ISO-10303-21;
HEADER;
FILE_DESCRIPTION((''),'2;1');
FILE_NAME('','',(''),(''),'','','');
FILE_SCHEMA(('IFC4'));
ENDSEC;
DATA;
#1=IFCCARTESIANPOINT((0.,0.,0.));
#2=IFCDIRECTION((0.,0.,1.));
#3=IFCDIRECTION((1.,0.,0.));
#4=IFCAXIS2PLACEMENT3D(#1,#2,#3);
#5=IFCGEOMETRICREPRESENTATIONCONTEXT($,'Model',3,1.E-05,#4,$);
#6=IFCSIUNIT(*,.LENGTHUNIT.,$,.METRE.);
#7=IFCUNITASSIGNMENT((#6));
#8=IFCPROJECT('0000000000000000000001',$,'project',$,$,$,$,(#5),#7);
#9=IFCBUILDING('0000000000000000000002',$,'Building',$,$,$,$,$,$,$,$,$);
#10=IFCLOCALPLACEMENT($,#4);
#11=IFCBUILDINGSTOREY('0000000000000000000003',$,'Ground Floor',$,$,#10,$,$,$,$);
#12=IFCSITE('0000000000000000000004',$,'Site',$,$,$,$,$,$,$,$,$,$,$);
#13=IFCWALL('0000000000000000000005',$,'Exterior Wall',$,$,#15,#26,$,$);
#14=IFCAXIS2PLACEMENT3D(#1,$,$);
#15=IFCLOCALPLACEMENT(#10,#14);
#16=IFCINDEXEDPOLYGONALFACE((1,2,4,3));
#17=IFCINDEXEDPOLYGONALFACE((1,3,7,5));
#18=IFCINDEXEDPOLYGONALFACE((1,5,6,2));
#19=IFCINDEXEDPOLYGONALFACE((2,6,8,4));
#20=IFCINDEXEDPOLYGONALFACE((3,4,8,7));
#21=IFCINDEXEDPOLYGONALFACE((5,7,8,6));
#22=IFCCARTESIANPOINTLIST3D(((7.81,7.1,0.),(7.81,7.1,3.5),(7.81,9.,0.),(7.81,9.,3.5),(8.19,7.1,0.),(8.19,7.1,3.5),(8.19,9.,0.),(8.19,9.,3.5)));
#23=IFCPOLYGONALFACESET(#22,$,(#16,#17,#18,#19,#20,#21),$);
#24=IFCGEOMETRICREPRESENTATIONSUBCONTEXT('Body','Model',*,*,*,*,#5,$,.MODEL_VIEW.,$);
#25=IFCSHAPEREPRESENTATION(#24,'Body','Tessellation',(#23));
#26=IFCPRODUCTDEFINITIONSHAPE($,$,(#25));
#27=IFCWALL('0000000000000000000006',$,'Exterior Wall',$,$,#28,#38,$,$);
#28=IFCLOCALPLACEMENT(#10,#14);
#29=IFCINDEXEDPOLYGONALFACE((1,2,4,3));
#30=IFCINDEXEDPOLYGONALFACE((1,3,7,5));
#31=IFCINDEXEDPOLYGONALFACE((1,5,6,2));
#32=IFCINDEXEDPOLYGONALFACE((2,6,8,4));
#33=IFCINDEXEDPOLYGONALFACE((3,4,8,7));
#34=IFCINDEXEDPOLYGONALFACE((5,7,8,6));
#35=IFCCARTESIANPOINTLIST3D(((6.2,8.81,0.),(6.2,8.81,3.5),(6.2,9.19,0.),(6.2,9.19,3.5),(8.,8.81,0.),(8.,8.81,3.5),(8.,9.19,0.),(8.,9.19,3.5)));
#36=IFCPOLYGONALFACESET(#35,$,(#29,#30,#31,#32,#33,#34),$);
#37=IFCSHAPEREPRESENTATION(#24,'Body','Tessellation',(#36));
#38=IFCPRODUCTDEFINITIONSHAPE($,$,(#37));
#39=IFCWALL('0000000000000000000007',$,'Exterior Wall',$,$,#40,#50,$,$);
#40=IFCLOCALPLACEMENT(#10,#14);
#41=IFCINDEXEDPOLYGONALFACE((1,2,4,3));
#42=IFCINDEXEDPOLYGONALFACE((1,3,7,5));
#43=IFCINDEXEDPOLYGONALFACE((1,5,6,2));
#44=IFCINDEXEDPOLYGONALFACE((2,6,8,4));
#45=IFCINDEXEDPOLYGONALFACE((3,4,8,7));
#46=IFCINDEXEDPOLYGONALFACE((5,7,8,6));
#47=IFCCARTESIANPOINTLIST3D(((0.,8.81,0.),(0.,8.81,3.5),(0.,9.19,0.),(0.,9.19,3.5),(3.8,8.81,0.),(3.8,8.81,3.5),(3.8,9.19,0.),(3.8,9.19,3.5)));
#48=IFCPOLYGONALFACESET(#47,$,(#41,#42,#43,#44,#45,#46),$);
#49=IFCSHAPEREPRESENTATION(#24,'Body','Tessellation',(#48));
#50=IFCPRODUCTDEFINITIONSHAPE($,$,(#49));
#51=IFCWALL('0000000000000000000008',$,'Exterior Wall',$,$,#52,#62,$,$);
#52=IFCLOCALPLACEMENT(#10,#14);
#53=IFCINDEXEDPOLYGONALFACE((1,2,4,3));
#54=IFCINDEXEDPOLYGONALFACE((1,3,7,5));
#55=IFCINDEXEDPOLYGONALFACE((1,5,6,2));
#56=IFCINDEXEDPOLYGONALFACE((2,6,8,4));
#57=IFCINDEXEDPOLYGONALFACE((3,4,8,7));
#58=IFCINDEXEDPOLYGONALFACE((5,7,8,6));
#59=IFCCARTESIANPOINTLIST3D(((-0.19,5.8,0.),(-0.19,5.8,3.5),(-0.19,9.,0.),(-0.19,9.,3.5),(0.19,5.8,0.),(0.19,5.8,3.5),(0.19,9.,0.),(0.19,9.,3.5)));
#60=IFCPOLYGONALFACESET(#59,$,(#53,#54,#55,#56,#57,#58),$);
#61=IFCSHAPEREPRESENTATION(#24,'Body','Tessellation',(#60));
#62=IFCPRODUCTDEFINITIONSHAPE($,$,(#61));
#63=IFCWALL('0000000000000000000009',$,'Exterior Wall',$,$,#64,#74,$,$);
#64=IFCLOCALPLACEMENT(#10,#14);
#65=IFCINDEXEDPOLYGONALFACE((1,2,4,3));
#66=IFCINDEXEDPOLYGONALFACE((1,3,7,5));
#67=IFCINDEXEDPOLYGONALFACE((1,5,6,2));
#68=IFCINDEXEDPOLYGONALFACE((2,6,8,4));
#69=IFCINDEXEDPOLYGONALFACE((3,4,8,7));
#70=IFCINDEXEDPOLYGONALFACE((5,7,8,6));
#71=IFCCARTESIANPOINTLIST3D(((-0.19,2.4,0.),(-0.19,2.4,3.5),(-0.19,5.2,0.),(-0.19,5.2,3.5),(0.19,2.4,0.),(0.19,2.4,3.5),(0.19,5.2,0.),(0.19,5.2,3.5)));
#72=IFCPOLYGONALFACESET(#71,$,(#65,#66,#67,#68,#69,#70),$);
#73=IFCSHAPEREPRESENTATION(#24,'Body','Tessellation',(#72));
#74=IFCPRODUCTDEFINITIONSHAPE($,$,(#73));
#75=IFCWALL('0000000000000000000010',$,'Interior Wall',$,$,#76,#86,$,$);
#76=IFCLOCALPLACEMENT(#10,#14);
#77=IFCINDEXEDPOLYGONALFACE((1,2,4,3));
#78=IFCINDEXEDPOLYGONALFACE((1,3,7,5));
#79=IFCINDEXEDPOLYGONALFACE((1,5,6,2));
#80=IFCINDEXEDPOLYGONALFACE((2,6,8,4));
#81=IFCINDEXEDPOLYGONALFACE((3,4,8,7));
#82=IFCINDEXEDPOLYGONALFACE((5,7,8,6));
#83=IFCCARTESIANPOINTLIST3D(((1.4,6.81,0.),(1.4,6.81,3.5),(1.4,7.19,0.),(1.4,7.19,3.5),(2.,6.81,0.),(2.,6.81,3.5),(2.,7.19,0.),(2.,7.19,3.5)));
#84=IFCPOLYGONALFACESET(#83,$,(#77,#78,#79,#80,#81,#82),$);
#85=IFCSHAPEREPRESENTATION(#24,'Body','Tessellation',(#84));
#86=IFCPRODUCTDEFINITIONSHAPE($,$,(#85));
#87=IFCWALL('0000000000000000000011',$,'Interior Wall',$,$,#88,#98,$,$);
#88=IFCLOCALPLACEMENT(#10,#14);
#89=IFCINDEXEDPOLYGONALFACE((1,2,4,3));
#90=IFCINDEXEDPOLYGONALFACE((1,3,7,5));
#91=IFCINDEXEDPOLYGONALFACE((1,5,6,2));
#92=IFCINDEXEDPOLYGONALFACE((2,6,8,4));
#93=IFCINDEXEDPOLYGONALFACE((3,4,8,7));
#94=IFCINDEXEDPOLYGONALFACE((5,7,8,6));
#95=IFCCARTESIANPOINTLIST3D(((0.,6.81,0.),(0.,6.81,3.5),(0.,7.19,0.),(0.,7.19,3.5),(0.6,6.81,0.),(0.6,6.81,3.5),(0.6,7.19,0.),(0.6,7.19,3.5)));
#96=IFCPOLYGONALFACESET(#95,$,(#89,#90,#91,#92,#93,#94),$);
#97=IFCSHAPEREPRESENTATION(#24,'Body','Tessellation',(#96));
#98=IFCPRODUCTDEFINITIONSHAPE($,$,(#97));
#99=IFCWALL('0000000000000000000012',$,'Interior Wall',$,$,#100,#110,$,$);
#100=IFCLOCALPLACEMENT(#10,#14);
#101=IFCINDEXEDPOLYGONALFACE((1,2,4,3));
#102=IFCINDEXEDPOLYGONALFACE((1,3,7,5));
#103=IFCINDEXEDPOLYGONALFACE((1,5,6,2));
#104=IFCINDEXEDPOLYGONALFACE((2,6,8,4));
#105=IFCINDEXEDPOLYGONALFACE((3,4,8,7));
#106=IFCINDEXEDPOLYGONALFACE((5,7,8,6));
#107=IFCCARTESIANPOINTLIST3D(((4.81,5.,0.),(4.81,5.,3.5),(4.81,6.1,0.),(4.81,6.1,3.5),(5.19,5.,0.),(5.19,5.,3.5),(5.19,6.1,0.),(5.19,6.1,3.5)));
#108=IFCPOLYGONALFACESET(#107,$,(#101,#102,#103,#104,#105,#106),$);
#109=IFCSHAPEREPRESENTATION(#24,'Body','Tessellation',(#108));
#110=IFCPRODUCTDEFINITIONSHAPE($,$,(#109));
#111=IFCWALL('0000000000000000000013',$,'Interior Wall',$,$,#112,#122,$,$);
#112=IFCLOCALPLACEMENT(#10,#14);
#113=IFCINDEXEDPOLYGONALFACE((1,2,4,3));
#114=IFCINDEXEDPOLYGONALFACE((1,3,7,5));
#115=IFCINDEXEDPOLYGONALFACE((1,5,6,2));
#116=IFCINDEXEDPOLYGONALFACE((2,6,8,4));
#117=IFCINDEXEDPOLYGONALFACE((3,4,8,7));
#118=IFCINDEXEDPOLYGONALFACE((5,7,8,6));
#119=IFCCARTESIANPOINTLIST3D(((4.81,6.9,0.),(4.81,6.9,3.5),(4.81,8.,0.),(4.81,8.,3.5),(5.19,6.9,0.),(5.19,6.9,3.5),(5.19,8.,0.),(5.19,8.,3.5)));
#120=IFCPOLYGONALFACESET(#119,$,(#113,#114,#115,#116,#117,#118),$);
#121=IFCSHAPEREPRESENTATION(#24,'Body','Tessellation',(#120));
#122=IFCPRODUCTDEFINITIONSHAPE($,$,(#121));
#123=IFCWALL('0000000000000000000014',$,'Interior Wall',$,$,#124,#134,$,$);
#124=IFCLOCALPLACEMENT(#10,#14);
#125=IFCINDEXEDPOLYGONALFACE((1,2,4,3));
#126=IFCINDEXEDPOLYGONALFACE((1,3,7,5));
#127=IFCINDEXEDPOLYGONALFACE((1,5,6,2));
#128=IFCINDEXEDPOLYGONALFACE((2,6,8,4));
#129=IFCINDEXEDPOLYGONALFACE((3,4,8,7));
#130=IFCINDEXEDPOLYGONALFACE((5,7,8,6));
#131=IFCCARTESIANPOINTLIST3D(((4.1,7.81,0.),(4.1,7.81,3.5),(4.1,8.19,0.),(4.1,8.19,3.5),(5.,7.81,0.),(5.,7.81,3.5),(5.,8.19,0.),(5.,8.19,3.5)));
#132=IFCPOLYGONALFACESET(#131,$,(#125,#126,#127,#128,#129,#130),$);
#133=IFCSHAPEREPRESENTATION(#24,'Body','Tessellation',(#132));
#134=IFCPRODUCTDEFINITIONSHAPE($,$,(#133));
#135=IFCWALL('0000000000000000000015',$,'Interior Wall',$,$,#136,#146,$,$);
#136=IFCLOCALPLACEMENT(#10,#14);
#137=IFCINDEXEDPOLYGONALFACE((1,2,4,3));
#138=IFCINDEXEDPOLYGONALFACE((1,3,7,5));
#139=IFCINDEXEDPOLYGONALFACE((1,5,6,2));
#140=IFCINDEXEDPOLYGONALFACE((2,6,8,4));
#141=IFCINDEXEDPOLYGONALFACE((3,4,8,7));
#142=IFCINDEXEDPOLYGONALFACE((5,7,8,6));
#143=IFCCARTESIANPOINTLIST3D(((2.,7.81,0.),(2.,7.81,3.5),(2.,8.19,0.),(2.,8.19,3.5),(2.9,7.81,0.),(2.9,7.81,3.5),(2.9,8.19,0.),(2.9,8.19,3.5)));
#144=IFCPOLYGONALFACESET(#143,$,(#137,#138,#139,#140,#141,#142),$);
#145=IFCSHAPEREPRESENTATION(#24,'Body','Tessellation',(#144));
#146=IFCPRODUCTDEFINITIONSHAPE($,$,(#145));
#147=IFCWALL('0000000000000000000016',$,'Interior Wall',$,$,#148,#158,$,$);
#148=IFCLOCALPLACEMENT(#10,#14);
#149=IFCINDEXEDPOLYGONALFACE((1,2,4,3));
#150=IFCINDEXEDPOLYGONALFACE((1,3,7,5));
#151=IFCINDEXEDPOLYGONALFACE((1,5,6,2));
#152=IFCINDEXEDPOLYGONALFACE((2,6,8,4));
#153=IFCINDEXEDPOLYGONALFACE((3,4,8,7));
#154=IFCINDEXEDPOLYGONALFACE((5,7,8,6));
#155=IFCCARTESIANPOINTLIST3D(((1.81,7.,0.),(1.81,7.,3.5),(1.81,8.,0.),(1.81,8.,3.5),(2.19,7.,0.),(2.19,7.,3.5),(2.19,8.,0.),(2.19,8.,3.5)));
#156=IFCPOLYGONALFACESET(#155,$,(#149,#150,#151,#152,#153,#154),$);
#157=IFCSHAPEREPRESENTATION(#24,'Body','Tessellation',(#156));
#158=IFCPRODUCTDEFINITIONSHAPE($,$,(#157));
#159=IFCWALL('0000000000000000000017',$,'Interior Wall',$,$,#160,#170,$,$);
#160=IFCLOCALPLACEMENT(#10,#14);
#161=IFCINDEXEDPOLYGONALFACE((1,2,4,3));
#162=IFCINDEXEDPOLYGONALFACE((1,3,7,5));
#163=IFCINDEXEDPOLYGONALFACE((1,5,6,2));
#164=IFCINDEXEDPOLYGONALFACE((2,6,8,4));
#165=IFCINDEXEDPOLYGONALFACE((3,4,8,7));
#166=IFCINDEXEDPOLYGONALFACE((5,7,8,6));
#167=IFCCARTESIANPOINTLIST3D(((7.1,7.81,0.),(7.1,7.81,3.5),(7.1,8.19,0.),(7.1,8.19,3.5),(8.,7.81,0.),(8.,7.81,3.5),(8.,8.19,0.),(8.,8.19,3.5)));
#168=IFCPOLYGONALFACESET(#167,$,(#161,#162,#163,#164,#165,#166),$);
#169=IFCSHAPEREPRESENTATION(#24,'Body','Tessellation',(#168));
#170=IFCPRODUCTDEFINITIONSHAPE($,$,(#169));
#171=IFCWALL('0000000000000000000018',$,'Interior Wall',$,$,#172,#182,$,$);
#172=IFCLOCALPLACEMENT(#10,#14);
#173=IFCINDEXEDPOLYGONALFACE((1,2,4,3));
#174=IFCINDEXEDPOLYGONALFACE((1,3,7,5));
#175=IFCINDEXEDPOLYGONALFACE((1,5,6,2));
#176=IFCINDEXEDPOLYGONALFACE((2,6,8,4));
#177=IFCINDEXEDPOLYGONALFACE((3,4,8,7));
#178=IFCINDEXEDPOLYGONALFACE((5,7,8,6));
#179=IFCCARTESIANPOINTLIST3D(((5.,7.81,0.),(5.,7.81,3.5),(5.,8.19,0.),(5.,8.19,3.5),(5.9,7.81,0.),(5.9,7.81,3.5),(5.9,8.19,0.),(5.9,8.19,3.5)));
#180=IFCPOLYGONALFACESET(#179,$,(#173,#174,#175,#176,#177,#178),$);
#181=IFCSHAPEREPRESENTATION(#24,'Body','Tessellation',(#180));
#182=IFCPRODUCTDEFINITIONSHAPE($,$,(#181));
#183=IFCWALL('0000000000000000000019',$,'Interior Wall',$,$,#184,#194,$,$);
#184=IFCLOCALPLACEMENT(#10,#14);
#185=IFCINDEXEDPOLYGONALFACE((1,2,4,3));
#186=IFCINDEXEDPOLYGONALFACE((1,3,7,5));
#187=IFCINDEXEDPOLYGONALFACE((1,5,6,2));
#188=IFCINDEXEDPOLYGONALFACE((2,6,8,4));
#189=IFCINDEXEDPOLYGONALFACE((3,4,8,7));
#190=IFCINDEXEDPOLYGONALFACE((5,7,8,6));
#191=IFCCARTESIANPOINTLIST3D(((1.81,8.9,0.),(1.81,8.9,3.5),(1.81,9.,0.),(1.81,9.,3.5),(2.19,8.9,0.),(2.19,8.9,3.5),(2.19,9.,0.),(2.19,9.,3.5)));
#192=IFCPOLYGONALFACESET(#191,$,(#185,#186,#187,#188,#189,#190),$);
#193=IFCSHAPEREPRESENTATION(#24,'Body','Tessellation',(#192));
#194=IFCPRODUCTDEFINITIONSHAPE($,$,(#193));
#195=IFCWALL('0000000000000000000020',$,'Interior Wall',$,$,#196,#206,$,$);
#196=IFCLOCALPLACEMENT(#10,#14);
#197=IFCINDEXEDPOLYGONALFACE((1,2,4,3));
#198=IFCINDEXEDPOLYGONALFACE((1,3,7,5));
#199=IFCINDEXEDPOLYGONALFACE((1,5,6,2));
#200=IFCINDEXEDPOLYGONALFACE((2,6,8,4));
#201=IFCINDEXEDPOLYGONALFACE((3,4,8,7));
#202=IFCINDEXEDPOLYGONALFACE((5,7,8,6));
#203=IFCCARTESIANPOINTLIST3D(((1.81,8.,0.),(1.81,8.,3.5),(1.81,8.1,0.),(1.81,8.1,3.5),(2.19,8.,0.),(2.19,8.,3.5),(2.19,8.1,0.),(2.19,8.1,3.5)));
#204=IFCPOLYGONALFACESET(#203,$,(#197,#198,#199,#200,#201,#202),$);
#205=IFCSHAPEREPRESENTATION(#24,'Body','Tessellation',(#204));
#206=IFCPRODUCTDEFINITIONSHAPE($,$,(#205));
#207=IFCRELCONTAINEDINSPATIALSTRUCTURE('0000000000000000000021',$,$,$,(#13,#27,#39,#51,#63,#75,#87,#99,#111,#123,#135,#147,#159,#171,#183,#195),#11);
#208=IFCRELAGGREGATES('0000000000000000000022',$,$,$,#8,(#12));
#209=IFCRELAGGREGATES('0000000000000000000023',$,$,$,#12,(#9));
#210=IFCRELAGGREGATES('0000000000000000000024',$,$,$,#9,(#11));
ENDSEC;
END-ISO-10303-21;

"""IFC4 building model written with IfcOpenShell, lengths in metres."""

from ifc_helpers import new_model, si_unit, frame, origin_with_axes, place, context, subcontext, project, spatial, indexed_curve, outline, extrude, element, save


model = new_model("IFC4")

# Units and contexts
model_context = context("Model", 3, precision=1e-05, world=origin_with_axes())
body_context = subcontext(model_context, "Body", "Model", "MODEL_VIEW")
ifc_project = project(units=[si_unit("LENGTHUNIT", "METRE")], contexts=[model_context])

# Site, building, storey
site = spatial("IfcSite", under=ifc_project, Name="Site")
building = spatial("IfcBuilding", under=site, Name="Building")
storey_placement = place(None, origin_with_axes())
storey = spatial("IfcBuildingStorey", under=building, at=storey_placement, Name="Ground Floor")

# Walls
wall_1_placement = place(storey_placement, frame((8.0, 7.1, 0.0), z_axis=(0.0, 0.0, 1.0), x_axis=(0.0, 1.0, 0.0)))
element("IfcWall", 1, at=wall_1_placement, inside=storey, Name="Exterior Wall", context=body_context, shape_type="SweptSolid", body=[
    extrude(outline(indexed_curve([(0.0, 0.0), (0.0, 0.38), (1.9, 0.38), (1.9, 0.0), (0.0, 0.0)], self_intersect=False)), frame((0.0, -0.19, 0.0), z_axis=(0.0, 0.0, 1.0), x_axis=(1.0, 0.0, 0.0)), (0.0, 0.0, 1.0), 3.5),
])
wall_2_placement = place(storey_placement, frame((8.0, 9.0, 0.0), z_axis=(0.0, 0.0, 1.0), x_axis=(-1.0, 0.0, 0.0)))
element("IfcWall", 2, at=wall_2_placement, inside=storey, Name="Exterior Wall", context=body_context, shape_type="SweptSolid", body=[
    extrude(outline(indexed_curve([(0.0, 0.0), (0.0, 0.38), (1.8, 0.38), (1.8, 0.0), (0.0, 0.0)], self_intersect=False)), frame((0.0, -0.19, 0.0), z_axis=(0.0, 0.0, 1.0), x_axis=(1.0, 0.0, 0.0)), (0.0, 0.0, 1.0), 3.5),
])
wall_3_placement = place(storey_placement, frame((3.8, 9.0, 0.0), z_axis=(0.0, 0.0, 1.0), x_axis=(-1.0, 0.0, 0.0)))
element("IfcWall", 3, at=wall_3_placement, inside=storey, Name="Exterior Wall", context=body_context, shape_type="SweptSolid", body=[
    extrude(outline(indexed_curve([(0.0, 0.0), (0.0, 0.38), (3.8, 0.38), (3.8, 0.0), (0.0, 0.0)], self_intersect=False)), frame((0.0, -0.19, 0.0), z_axis=(0.0, 0.0, 1.0), x_axis=(1.0, 0.0, 0.0)), (0.0, 0.0, 1.0), 3.5),
])
wall_4_placement = place(storey_placement, frame((0.0, 9.0, 0.0), z_axis=(0.0, 0.0, 1.0), x_axis=(0.0, -1.0, 0.0)))
element("IfcWall", 4, at=wall_4_placement, inside=storey, Name="Exterior Wall", context=body_context, shape_type="SweptSolid", body=[
    extrude(outline(indexed_curve([(0.0, 0.0), (0.0, 0.38), (3.2, 0.38), (3.2, 0.0), (0.0, 0.0)], self_intersect=False)), frame((0.0, -0.19, 0.0), z_axis=(0.0, 0.0, 1.0), x_axis=(1.0, 0.0, 0.0)), (0.0, 0.0, 1.0), 3.5),
])
wall_5_placement = place(storey_placement, frame((0.0, 5.2, 0.0), z_axis=(0.0, 0.0, 1.0), x_axis=(0.0, -1.0, 0.0)))
element("IfcWall", 5, at=wall_5_placement, inside=storey, Name="Exterior Wall", context=body_context, shape_type="SweptSolid", body=[
    extrude(outline(indexed_curve([(0.0, 0.0), (0.0, 0.38), (2.8, 0.38), (2.8, 0.0), (0.0, 0.0)], self_intersect=False)), frame((0.0, -0.19, 0.0), z_axis=(0.0, 0.0, 1.0), x_axis=(1.0, 0.0, 0.0)), (0.0, 0.0, 1.0), 3.5),
])
for number, where, z_axis, x_axis, name in (
    (6, (2.0, 7.0, 0.0), (0.0, 0.0, 1.0), (-1.0, 0.0, 0.0), "Interior Wall"),
    (7, (0.6, 7.0, 0.0), (0.0, 0.0, 1.0), (-1.0, 0.0, 0.0), "Interior Wall"),
):
    element("IfcWall", number, at=place(storey_placement, frame(where, z_axis=z_axis, x_axis=x_axis)), inside=storey, Name=name, context=body_context, shape_type="SweptSolid", body=[
        extrude(outline(indexed_curve([(0.0, 0.0), (0.0, 0.38), (0.6, 0.38), (0.6, 0.0), (0.0, 0.0)], self_intersect=False)), frame((0.0, -0.19, 0.0), z_axis=(0.0, 0.0, 1.0), x_axis=(1.0, 0.0, 0.0)), (0.0, 0.0, 1.0), 3.5),
    ])
for number, where, z_axis, x_axis, name in (
    (8, (5.0, 5.0, 0.0), (0.0, 0.0, 1.0), (0.0, 1.0, 0.0), "Interior Wall"),
    (9, (5.0, 6.9, 0.0), (0.0, 0.0, 1.0), (0.0, 1.0, 0.0), "Interior Wall"),
):
    element("IfcWall", number, at=place(storey_placement, frame(where, z_axis=z_axis, x_axis=x_axis)), inside=storey, Name=name, context=body_context, shape_type="SweptSolid", body=[
        extrude(outline(indexed_curve([(0.0, 0.0), (0.0, 0.38), (1.1, 0.38), (1.1, 0.0), (0.0, 0.0)], self_intersect=False)), frame((0.0, -0.19, 0.0), z_axis=(0.0, 0.0, 1.0), x_axis=(1.0, 0.0, 0.0)), (0.0, 0.0, 1.0), 3.5),
    ])
wall_6_placement = place(storey_placement, frame((5.0, 8.0, 0.0), z_axis=(0.0, 0.0, 1.0), x_axis=(-1.0, 0.0, 0.0)))
element("IfcWall", 10, at=wall_6_placement, inside=storey, Name="Interior Wall", context=body_context, shape_type="SweptSolid", body=[
    extrude(outline(indexed_curve([(0.0, 0.0), (0.0, 0.38), (0.9, 0.38), (0.9, 0.0), (0.0, 0.0)], self_intersect=False)), frame((0.0, -0.19, 0.0), z_axis=(0.0, 0.0, 1.0), x_axis=(1.0, 0.0, 0.0)), (0.0, 0.0, 1.0), 3.5),
])
wall_7_placement = place(storey_placement, frame((2.9, 8.0, 0.0), z_axis=(0.0, 0.0, 1.0), x_axis=(-1.0, 0.0, 0.0)))
element("IfcWall", 11, at=wall_7_placement, inside=storey, Name="Interior Wall", context=body_context, shape_type="SweptSolid", body=[
    extrude(outline(indexed_curve([(0.0, 0.0), (0.0, 0.38), (0.9, 0.38), (0.9, 0.0), (0.0, 0.0)], self_intersect=False)), frame((0.0, -0.19, 0.0), z_axis=(0.0, 0.0, 1.0), x_axis=(1.0, 0.0, 0.0)), (0.0, 0.0, 1.0), 3.5),
])
wall_8_placement = place(storey_placement, frame((2.0, 8.0, 0.0), z_axis=(0.0, 0.0, 1.0), x_axis=(0.0, -1.0, 0.0)))
element("IfcWall", 12, at=wall_8_placement, inside=storey, Name="Interior Wall", context=body_context, shape_type="SweptSolid", body=[
    extrude(outline(indexed_curve([(0.0, 0.0), (0.0, 0.38), (1.0, 0.38), (1.0, 0.0), (0.0, 0.0)], self_intersect=False)), frame((0.0, -0.19, 0.0), z_axis=(0.0, 0.0, 1.0), x_axis=(1.0, 0.0, 0.0)), (0.0, 0.0, 1.0), 3.5),
])
for number, where, z_axis, x_axis, name in (
    (13, (8.0, 8.0, 0.0), (0.0, 0.0, 1.0), (-1.0, 0.0, 0.0), "Interior Wall"),
    (14, (5.9, 8.0, 0.0), (0.0, 0.0, 1.0), (-1.0, 0.0, 0.0), "Interior Wall"),
):
    element("IfcWall", number, at=place(storey_placement, frame(where, z_axis=z_axis, x_axis=x_axis)), inside=storey, Name=name, context=body_context, shape_type="SweptSolid", body=[
        extrude(outline(indexed_curve([(0.0, 0.0), (0.0, 0.38), (0.9, 0.38), (0.9, 0.0), (0.0, 0.0)], self_intersect=False)), frame((0.0, -0.19, 0.0), z_axis=(0.0, 0.0, 1.0), x_axis=(1.0, 0.0, 0.0)), (0.0, 0.0, 1.0), 3.5),
    ])
for number, where, z_axis, x_axis, name in (
    (15, (2.0, 9.0, 0.0), (0.0, 0.0, 1.0), (0.0, -1.0, 0.0), "Interior Wall"),
    (16, (2.0, 8.1, 0.0), (0.0, 0.0, 1.0), (0.0, -1.0, 0.0), "Interior Wall"),
):
    element("IfcWall", number, at=place(storey_placement, frame(where, z_axis=z_axis, x_axis=x_axis)), inside=storey, Name=name, context=body_context, shape_type="SweptSolid", body=[
        extrude(outline(indexed_curve([(0.0, 0.0), (0.0, 0.38), (0.1, 0.38), (0.1, 0.0), (0.0, 0.0)], self_intersect=False)), frame((0.0, -0.19, 0.0), z_axis=(0.0, 0.0, 1.0), x_axis=(1.0, 0.0, 0.0)), (0.0, 0.0, 1.0), 3.5),
    ])

save(model, "model.ifc")
